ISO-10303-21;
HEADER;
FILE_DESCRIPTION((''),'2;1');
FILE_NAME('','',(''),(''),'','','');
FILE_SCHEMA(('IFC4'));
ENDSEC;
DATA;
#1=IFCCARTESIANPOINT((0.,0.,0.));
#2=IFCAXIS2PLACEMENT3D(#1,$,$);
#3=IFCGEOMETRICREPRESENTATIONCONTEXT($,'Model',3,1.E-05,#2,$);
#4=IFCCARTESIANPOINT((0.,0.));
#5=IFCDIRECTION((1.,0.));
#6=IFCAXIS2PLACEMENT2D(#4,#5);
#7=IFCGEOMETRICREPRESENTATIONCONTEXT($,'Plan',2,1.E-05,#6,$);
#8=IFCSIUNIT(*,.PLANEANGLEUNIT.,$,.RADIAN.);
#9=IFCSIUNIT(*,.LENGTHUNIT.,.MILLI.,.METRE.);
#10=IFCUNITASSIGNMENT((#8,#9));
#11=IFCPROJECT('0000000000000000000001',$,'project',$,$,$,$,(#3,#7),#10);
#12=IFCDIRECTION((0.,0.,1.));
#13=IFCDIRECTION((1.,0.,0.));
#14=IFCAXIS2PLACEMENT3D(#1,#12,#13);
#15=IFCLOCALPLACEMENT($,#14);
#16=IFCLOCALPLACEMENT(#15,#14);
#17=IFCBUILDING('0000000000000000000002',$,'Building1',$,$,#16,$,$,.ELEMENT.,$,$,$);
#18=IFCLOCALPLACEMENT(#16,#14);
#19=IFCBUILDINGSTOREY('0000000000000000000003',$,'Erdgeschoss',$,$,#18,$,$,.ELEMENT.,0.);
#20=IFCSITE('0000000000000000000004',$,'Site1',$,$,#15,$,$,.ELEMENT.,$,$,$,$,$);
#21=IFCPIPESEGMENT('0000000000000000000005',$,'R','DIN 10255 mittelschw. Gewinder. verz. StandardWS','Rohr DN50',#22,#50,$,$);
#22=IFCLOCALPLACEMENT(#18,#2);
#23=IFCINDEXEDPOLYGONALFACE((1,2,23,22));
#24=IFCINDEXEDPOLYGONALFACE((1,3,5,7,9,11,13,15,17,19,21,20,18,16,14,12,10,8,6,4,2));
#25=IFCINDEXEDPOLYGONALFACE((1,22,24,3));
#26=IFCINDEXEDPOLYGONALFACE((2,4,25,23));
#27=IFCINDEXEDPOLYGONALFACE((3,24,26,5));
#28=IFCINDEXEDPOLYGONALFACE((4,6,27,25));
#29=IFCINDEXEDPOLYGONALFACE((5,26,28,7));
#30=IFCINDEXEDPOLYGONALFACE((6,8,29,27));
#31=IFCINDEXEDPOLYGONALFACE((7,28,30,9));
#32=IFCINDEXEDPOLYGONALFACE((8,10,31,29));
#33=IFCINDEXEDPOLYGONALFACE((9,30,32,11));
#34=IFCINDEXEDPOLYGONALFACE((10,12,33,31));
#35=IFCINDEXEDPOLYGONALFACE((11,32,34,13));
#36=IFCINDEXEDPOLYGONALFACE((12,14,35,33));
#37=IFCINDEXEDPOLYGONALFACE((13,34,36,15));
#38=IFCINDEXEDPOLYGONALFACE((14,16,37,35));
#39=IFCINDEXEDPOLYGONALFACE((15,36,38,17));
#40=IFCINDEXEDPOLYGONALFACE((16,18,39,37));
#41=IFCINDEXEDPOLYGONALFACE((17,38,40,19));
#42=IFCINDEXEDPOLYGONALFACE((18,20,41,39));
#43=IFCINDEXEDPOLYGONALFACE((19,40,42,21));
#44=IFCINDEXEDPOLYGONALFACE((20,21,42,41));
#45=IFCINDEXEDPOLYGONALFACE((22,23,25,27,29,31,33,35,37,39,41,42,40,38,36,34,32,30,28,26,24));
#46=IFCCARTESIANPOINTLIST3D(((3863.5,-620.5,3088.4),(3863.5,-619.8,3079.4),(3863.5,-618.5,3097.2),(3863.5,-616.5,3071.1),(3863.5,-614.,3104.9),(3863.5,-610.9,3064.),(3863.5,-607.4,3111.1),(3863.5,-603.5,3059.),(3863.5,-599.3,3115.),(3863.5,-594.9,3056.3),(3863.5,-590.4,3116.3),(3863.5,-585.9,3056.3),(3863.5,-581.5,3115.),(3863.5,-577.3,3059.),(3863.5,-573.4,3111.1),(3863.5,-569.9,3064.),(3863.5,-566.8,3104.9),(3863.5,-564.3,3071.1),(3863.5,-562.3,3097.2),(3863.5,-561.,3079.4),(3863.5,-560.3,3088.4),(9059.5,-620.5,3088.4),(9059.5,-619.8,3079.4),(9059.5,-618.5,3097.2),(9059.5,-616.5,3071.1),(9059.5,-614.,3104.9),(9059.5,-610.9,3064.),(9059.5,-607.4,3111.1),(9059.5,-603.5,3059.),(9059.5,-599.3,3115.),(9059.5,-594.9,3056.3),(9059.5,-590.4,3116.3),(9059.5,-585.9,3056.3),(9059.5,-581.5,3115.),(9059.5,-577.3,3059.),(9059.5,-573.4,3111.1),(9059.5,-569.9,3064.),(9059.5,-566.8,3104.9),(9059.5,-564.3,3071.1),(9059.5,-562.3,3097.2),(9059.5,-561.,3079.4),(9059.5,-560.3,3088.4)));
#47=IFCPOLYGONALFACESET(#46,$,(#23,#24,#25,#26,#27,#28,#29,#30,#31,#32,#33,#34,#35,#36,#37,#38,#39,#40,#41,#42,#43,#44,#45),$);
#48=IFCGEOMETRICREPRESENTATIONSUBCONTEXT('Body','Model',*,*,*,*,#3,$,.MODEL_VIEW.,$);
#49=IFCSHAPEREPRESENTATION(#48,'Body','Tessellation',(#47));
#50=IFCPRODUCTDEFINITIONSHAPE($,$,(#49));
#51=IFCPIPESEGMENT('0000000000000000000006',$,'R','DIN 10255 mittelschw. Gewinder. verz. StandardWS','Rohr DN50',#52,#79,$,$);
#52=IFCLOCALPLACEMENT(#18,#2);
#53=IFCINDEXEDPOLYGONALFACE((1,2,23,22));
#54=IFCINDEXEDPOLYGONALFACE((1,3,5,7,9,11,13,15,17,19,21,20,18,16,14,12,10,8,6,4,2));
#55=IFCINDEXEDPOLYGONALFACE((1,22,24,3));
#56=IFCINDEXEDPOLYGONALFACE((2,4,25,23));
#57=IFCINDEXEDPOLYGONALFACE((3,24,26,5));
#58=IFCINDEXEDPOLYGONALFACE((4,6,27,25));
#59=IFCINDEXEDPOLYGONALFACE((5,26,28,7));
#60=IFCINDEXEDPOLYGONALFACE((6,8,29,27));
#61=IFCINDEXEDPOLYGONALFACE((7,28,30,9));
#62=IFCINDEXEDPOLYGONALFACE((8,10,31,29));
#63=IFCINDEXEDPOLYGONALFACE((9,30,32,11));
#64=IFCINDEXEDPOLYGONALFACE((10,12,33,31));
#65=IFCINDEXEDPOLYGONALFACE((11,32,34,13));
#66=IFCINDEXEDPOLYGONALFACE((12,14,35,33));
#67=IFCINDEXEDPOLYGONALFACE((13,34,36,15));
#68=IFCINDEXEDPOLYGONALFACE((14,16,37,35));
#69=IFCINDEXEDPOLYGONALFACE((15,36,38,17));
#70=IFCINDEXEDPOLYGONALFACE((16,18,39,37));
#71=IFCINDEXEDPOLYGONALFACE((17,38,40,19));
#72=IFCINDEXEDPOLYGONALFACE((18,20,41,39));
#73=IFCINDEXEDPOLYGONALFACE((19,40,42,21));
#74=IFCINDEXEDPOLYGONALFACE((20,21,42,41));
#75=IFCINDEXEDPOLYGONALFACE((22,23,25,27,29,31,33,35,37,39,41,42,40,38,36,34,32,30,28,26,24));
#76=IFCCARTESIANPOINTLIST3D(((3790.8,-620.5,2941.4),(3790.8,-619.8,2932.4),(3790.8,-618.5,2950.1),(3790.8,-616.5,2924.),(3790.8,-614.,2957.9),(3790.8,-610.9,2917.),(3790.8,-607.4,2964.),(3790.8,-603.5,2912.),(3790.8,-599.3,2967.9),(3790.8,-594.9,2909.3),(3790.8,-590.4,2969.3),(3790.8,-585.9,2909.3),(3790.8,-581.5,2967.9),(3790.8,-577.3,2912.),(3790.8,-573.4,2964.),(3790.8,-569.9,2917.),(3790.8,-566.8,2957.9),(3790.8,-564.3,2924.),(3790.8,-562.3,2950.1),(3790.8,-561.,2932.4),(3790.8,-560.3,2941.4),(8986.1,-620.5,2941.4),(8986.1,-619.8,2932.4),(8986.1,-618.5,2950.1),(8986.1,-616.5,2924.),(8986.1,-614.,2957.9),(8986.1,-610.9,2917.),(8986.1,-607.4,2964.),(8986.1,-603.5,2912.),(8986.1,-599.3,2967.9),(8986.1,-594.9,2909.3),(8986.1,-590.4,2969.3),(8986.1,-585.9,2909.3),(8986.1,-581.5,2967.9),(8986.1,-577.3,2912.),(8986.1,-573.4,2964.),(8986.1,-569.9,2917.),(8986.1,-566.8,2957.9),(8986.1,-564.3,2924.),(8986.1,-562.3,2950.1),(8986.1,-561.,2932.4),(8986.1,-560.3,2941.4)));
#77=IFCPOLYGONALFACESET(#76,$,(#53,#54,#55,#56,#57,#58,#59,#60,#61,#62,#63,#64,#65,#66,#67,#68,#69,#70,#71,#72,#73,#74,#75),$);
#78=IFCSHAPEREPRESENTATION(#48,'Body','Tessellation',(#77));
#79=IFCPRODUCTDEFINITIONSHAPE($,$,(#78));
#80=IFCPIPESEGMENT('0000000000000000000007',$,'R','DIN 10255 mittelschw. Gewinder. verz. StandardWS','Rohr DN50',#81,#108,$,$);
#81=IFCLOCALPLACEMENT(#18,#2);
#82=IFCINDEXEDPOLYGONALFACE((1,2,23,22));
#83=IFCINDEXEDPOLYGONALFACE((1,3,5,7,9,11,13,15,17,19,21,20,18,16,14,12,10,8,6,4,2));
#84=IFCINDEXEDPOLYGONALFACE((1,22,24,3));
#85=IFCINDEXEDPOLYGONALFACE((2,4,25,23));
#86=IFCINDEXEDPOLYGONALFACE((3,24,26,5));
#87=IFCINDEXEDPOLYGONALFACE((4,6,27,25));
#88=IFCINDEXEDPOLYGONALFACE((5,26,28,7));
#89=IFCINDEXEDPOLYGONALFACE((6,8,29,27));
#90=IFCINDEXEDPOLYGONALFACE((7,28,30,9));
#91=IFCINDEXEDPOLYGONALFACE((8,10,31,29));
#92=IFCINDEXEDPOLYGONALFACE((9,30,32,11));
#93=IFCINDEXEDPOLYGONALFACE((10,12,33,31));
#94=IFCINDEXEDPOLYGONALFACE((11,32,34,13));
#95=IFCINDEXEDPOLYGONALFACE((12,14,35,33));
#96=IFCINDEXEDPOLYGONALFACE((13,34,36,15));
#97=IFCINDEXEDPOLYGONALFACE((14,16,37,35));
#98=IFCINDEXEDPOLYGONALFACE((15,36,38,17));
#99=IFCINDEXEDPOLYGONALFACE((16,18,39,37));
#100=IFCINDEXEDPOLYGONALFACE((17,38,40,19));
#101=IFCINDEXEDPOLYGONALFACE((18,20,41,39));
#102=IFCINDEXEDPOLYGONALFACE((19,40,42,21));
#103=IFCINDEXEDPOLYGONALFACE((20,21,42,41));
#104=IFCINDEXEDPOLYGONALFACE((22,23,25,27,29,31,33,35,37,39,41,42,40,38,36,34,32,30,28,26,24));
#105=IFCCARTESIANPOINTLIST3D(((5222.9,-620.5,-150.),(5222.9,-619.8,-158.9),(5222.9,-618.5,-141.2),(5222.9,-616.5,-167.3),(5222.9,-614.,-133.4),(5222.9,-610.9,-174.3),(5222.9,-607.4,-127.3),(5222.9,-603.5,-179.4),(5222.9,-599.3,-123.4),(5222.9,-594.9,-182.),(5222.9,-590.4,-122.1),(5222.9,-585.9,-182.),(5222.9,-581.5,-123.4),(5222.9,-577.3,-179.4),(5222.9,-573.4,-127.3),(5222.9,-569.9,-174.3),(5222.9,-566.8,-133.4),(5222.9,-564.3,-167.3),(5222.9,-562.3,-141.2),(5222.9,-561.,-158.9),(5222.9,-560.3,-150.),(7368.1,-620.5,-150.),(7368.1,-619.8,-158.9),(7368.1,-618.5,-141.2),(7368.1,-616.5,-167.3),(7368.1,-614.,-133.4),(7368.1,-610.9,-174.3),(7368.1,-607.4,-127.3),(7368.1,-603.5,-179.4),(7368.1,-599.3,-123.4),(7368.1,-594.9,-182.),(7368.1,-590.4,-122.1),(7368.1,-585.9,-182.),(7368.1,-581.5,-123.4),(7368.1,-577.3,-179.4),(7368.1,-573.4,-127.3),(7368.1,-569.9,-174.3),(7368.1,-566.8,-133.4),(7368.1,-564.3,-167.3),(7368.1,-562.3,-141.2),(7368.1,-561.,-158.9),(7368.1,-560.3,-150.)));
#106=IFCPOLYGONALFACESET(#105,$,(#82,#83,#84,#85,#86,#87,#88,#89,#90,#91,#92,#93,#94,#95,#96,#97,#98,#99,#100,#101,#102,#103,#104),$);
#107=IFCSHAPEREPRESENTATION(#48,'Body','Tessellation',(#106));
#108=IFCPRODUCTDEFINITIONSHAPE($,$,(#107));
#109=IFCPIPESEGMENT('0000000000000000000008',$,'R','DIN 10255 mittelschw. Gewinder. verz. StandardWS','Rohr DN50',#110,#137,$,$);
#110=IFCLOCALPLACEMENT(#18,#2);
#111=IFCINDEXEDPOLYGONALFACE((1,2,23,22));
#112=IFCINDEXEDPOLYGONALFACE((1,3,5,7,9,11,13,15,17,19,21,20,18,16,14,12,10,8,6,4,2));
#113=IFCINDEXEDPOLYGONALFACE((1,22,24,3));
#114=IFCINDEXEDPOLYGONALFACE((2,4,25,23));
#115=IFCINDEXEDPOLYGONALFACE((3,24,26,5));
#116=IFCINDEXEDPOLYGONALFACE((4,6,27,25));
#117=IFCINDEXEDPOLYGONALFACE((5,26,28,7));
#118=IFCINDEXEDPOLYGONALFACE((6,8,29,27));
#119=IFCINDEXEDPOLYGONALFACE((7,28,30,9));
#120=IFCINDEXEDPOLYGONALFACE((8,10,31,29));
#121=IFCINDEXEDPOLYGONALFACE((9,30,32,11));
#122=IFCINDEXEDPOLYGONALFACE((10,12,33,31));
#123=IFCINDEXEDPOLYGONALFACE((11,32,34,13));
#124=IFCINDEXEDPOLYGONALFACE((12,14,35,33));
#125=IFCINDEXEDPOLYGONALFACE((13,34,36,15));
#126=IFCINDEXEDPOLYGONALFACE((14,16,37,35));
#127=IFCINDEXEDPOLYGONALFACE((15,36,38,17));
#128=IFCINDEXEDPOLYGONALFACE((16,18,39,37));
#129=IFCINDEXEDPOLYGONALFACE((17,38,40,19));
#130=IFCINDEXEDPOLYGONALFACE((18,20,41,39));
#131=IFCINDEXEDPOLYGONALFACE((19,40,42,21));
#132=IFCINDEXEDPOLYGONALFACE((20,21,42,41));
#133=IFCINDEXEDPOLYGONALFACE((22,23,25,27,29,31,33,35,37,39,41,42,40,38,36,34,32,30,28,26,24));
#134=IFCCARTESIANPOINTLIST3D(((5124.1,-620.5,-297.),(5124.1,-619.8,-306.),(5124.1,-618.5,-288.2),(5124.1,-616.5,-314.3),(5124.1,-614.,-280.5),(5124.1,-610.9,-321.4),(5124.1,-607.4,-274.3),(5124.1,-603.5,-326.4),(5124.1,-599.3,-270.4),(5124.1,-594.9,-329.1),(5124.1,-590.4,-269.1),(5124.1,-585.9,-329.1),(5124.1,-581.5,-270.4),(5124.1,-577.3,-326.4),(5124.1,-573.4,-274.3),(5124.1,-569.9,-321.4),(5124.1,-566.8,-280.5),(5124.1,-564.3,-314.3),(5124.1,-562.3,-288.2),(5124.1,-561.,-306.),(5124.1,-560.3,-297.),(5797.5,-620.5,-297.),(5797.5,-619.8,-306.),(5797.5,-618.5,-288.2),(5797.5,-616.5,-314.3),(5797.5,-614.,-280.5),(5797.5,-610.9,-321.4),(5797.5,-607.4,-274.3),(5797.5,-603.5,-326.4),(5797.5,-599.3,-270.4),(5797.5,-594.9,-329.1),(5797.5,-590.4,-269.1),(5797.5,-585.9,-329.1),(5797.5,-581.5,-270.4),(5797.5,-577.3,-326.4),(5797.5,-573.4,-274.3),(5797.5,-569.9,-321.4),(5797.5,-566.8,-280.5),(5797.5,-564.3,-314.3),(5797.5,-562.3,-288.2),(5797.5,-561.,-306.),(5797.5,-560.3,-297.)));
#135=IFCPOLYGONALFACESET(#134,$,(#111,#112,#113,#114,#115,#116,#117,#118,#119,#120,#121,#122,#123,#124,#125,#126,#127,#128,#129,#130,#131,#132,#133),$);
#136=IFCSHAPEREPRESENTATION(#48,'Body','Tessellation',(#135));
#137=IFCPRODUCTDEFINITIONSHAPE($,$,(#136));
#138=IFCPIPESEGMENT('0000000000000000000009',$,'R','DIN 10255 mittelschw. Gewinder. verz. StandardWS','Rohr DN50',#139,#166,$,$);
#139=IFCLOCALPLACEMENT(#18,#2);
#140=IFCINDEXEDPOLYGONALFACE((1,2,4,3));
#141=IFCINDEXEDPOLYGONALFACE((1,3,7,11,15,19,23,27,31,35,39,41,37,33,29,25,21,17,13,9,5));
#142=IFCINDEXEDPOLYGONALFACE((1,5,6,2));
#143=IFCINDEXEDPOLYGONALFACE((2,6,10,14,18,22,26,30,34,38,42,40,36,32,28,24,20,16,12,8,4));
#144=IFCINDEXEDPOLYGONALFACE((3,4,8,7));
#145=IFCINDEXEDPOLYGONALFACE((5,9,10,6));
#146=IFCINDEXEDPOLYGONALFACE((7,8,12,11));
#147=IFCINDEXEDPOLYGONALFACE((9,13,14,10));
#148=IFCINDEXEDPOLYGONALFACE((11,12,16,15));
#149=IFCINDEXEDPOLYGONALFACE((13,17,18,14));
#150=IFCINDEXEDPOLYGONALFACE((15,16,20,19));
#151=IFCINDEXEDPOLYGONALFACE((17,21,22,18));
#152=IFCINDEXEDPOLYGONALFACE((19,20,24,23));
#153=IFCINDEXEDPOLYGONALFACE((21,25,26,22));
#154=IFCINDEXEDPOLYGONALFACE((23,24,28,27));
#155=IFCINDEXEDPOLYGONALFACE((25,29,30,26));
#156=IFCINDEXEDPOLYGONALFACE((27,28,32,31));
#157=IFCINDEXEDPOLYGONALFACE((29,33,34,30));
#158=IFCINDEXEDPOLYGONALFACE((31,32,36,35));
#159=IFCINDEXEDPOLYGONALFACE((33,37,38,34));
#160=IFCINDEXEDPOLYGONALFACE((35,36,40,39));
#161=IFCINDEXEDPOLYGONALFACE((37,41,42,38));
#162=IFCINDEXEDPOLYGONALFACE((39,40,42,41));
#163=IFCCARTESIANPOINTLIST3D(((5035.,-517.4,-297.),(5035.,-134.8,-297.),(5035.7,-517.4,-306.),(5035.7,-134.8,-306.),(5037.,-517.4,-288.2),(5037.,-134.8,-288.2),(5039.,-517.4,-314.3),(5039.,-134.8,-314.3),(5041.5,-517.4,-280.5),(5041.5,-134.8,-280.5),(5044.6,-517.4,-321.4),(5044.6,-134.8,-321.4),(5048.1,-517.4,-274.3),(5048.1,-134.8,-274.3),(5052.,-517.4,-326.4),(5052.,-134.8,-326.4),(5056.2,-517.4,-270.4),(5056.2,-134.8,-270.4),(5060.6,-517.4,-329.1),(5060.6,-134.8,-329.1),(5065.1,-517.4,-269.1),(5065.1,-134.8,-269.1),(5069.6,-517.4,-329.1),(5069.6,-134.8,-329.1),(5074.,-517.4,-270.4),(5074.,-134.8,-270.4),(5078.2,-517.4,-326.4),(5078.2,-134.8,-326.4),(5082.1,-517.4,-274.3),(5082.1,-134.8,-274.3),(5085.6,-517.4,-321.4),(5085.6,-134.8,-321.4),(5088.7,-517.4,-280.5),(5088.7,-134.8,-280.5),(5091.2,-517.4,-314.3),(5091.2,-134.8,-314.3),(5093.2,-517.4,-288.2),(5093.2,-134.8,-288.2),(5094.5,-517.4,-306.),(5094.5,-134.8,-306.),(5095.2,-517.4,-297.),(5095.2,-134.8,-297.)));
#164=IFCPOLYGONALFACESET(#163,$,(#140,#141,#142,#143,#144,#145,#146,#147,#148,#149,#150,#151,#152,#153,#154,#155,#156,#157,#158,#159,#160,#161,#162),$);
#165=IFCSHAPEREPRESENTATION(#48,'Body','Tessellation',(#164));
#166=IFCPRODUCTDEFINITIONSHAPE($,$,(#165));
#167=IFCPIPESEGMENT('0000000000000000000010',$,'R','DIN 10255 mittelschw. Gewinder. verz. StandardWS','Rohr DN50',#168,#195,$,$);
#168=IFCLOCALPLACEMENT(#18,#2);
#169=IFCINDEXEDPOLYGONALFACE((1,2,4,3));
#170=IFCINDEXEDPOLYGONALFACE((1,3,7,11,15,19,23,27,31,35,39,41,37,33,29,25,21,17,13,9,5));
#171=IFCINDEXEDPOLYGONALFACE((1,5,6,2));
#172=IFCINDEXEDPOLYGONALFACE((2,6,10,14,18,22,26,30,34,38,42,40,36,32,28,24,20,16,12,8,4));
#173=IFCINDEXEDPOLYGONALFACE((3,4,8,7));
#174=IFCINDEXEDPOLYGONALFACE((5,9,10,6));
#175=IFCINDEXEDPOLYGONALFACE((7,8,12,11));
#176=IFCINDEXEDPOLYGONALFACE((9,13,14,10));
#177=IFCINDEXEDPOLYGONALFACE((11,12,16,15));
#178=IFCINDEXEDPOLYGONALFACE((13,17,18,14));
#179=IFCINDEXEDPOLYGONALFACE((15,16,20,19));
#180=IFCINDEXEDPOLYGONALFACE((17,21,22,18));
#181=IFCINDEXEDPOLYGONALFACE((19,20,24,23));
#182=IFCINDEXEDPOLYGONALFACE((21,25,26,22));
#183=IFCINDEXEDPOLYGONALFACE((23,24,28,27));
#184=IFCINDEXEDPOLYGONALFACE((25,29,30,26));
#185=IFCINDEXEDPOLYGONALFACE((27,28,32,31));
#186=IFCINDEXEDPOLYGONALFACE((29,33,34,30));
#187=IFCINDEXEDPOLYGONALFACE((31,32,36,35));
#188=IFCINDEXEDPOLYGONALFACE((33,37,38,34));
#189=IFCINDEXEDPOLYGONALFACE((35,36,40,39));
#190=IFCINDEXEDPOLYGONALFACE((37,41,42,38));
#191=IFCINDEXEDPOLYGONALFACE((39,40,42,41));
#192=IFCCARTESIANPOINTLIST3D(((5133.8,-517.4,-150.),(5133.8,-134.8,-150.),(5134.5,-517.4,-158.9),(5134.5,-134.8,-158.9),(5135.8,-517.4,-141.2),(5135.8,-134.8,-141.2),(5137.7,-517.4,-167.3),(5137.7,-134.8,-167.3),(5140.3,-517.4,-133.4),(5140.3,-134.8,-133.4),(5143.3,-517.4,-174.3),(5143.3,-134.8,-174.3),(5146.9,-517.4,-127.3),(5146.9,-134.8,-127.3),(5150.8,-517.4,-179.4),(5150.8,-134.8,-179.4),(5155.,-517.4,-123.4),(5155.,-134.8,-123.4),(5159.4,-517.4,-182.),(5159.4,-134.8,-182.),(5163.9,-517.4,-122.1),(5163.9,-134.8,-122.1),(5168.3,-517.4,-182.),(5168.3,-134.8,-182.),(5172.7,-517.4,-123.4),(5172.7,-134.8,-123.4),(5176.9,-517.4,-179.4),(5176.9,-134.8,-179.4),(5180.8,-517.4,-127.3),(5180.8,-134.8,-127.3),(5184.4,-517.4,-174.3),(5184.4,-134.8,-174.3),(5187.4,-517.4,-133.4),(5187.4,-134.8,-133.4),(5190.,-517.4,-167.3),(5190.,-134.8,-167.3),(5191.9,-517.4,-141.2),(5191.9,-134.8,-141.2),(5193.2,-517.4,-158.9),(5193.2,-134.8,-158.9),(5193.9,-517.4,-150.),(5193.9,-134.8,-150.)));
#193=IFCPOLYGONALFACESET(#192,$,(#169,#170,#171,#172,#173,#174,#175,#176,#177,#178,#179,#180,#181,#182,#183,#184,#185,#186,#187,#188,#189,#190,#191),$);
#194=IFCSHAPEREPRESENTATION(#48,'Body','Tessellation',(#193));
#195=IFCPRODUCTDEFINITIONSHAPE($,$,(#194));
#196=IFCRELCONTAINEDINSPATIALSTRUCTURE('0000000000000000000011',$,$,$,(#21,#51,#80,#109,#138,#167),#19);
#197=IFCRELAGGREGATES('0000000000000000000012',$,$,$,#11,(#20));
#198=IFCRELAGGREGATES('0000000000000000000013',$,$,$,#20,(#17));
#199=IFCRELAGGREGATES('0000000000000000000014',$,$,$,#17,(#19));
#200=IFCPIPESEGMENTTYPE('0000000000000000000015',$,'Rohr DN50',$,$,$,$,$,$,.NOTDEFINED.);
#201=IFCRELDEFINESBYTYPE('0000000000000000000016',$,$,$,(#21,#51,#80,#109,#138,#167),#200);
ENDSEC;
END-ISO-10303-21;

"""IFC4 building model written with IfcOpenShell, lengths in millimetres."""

from ifc_helpers import new_model, si_unit, frame, origin, origin_with_axes, origin_2d_with_axis, place, context, subcontext, project, spatial, circle, extrude, type_object, element, save


model = new_model("IFC4")

# Units and contexts
model_context = context("Model", 3, precision=1e-05, world=origin())
plan_context = context("Plan", 2, precision=1e-05, world=origin_2d_with_axis())
body_context = subcontext(model_context, "Body", "Model", "MODEL_VIEW")
ifc_project = project(units=[si_unit("PLANEANGLEUNIT", "RADIAN"), si_unit("LENGTHUNIT", "METRE", prefix="MILLI")], contexts=[model_context, plan_context])

# Site, building, storey
site_placement = place(None, origin_with_axes())
site = spatial("IfcSite", under=ifc_project, at=site_placement, Name="Site1", CompositionType="ELEMENT")
building_placement = place(site_placement, origin_with_axes())
building = spatial("IfcBuilding", under=site, at=building_placement, Name="Building1", CompositionType="ELEMENT")
storey_placement = place(building_placement, origin_with_axes())
storey = spatial("IfcBuildingStorey", under=building, at=storey_placement, Name="Erdgeschoss", CompositionType="ELEMENT", Elevation=0.0)

# Pipe segments
pipe_segment_type_1 = type_object("IfcPipeSegmentType", Name="Rohr DN50", PredefinedType="NOTDEFINED")
pipe_segment_1_placement = place(storey_placement, frame((6461.5, -590.3, 3086.1), z_axis=(0.0, 0.0, 1.0), x_axis=(1.0, 0.0, 0.0)))
element("IfcPipeSegment", 1, at=pipe_segment_1_placement, inside=storey, type_object=pipe_segment_type_1, Name="R", Description="DIN 10255 mittelschw. Gewinder. verz. StandardWS", ObjectType="Rohr DN50", context=body_context, shape_type="SolidModel", body=[
    extrude(circle(Radius=30.1, at=origin_2d_with_axis()), frame((-2598.0, -0.2, 0.0), z_axis=(1.0, 0.0, 0.0), x_axis=(0.0, 0.0, 1.0)), (0.0, 0.0, 1.0), 5196.0),
])
pipe_segment_2_placement = place(storey_placement, frame((6388.5, -590.3, 2939.1), z_axis=(0.0, 0.0, 1.0), x_axis=(1.0, 0.0, 0.0)))
element("IfcPipeSegment", 2, at=pipe_segment_2_placement, inside=storey, type_object=pipe_segment_type_1, Name="R", Description="DIN 10255 mittelschw. Gewinder. verz. StandardWS", ObjectType="Rohr DN50", context=body_context, shape_type="SolidModel", body=[
    extrude(circle(Radius=30.1, at=origin_2d_with_axis()), frame((-2597.7, -0.2, 0.0), z_axis=(1.0, 0.0, 0.0), x_axis=(0.0, 0.0, 1.0)), (0.0, 0.0, 1.0), 5195.4),
])
pipe_segment_3_placement = place(storey_placement, frame((6295.5, -590.3, -152.2), z_axis=(0.0, 0.0, 1.0), x_axis=(1.0, 0.0, 0.0)))
element("IfcPipeSegment", 3, at=pipe_segment_3_placement, inside=storey, type_object=pipe_segment_type_1, Name="R", Description="DIN 10255 mittelschw. Gewinder. verz. StandardWS", ObjectType="Rohr DN50", context=body_context, shape_type="SolidModel", body=[
    extrude(circle(Radius=30.1, at=origin_2d_with_axis()), frame((-1072.6, -0.2, 0.0), z_axis=(1.0, 0.0, 0.0), x_axis=(0.0, 0.0, 1.0)), (0.0, 0.0, 1.0), 2145.3),
])
pipe_segment_4_placement = place(storey_placement, frame((5460.8, -590.3, -299.2), z_axis=(0.0, 0.0, 1.0), x_axis=(1.0, 0.0, 0.0)))
element("IfcPipeSegment", 4, at=pipe_segment_4_placement, inside=storey, type_object=pipe_segment_type_1, Name="R", Description="DIN 10255 mittelschw. Gewinder. verz. StandardWS", ObjectType="Rohr DN50", context=body_context, shape_type="SolidModel", body=[
    extrude(circle(Radius=30.1, at=origin_2d_with_axis()), frame((-336.7, -0.2, 0.0), z_axis=(1.0, 0.0, 0.0), x_axis=(0.0, 0.0, 1.0)), (0.0, 0.0, 1.0), 673.4),
])
pipe_segment_5_placement = place(storey_placement, frame((5065.0, -326.1, -299.2), z_axis=(0.0, 0.0, 1.0), x_axis=(1.0, 0.0, 0.0)))
element("IfcPipeSegment", 5, at=pipe_segment_5_placement, inside=storey, type_object=pipe_segment_type_1, Name="R", Description="DIN 10255 mittelschw. Gewinder. verz. StandardWS", ObjectType="Rohr DN50", context=body_context, shape_type="SolidModel", body=[
    extrude(circle(Radius=30.1, at=origin_2d_with_axis()), frame((0.1, -191.3, 0.0), z_axis=(0.0, 1.0, 0.0), x_axis=(0.0, 0.0, 1.0)), (0.0, 0.0, 1.0), 382.6),
])
pipe_segment_6_placement = place(storey_placement, frame((5163.7, -326.1, -152.2), z_axis=(0.0, 0.0, 1.0), x_axis=(1.0, 0.0, 0.0)))
element("IfcPipeSegment", 6, at=pipe_segment_6_placement, inside=storey, type_object=pipe_segment_type_1, Name="R", Description="DIN 10255 mittelschw. Gewinder. verz. StandardWS", ObjectType="Rohr DN50", context=body_context, shape_type="SolidModel", body=[
    extrude(circle(Radius=30.1, at=origin_2d_with_axis()), frame((0.1, -191.3, 0.0), z_axis=(0.0, 1.0, 0.0), x_axis=(0.0, 0.0, 1.0)), (0.0, 0.0, 1.0), 382.6),
])

save(model, "model.ifc")
